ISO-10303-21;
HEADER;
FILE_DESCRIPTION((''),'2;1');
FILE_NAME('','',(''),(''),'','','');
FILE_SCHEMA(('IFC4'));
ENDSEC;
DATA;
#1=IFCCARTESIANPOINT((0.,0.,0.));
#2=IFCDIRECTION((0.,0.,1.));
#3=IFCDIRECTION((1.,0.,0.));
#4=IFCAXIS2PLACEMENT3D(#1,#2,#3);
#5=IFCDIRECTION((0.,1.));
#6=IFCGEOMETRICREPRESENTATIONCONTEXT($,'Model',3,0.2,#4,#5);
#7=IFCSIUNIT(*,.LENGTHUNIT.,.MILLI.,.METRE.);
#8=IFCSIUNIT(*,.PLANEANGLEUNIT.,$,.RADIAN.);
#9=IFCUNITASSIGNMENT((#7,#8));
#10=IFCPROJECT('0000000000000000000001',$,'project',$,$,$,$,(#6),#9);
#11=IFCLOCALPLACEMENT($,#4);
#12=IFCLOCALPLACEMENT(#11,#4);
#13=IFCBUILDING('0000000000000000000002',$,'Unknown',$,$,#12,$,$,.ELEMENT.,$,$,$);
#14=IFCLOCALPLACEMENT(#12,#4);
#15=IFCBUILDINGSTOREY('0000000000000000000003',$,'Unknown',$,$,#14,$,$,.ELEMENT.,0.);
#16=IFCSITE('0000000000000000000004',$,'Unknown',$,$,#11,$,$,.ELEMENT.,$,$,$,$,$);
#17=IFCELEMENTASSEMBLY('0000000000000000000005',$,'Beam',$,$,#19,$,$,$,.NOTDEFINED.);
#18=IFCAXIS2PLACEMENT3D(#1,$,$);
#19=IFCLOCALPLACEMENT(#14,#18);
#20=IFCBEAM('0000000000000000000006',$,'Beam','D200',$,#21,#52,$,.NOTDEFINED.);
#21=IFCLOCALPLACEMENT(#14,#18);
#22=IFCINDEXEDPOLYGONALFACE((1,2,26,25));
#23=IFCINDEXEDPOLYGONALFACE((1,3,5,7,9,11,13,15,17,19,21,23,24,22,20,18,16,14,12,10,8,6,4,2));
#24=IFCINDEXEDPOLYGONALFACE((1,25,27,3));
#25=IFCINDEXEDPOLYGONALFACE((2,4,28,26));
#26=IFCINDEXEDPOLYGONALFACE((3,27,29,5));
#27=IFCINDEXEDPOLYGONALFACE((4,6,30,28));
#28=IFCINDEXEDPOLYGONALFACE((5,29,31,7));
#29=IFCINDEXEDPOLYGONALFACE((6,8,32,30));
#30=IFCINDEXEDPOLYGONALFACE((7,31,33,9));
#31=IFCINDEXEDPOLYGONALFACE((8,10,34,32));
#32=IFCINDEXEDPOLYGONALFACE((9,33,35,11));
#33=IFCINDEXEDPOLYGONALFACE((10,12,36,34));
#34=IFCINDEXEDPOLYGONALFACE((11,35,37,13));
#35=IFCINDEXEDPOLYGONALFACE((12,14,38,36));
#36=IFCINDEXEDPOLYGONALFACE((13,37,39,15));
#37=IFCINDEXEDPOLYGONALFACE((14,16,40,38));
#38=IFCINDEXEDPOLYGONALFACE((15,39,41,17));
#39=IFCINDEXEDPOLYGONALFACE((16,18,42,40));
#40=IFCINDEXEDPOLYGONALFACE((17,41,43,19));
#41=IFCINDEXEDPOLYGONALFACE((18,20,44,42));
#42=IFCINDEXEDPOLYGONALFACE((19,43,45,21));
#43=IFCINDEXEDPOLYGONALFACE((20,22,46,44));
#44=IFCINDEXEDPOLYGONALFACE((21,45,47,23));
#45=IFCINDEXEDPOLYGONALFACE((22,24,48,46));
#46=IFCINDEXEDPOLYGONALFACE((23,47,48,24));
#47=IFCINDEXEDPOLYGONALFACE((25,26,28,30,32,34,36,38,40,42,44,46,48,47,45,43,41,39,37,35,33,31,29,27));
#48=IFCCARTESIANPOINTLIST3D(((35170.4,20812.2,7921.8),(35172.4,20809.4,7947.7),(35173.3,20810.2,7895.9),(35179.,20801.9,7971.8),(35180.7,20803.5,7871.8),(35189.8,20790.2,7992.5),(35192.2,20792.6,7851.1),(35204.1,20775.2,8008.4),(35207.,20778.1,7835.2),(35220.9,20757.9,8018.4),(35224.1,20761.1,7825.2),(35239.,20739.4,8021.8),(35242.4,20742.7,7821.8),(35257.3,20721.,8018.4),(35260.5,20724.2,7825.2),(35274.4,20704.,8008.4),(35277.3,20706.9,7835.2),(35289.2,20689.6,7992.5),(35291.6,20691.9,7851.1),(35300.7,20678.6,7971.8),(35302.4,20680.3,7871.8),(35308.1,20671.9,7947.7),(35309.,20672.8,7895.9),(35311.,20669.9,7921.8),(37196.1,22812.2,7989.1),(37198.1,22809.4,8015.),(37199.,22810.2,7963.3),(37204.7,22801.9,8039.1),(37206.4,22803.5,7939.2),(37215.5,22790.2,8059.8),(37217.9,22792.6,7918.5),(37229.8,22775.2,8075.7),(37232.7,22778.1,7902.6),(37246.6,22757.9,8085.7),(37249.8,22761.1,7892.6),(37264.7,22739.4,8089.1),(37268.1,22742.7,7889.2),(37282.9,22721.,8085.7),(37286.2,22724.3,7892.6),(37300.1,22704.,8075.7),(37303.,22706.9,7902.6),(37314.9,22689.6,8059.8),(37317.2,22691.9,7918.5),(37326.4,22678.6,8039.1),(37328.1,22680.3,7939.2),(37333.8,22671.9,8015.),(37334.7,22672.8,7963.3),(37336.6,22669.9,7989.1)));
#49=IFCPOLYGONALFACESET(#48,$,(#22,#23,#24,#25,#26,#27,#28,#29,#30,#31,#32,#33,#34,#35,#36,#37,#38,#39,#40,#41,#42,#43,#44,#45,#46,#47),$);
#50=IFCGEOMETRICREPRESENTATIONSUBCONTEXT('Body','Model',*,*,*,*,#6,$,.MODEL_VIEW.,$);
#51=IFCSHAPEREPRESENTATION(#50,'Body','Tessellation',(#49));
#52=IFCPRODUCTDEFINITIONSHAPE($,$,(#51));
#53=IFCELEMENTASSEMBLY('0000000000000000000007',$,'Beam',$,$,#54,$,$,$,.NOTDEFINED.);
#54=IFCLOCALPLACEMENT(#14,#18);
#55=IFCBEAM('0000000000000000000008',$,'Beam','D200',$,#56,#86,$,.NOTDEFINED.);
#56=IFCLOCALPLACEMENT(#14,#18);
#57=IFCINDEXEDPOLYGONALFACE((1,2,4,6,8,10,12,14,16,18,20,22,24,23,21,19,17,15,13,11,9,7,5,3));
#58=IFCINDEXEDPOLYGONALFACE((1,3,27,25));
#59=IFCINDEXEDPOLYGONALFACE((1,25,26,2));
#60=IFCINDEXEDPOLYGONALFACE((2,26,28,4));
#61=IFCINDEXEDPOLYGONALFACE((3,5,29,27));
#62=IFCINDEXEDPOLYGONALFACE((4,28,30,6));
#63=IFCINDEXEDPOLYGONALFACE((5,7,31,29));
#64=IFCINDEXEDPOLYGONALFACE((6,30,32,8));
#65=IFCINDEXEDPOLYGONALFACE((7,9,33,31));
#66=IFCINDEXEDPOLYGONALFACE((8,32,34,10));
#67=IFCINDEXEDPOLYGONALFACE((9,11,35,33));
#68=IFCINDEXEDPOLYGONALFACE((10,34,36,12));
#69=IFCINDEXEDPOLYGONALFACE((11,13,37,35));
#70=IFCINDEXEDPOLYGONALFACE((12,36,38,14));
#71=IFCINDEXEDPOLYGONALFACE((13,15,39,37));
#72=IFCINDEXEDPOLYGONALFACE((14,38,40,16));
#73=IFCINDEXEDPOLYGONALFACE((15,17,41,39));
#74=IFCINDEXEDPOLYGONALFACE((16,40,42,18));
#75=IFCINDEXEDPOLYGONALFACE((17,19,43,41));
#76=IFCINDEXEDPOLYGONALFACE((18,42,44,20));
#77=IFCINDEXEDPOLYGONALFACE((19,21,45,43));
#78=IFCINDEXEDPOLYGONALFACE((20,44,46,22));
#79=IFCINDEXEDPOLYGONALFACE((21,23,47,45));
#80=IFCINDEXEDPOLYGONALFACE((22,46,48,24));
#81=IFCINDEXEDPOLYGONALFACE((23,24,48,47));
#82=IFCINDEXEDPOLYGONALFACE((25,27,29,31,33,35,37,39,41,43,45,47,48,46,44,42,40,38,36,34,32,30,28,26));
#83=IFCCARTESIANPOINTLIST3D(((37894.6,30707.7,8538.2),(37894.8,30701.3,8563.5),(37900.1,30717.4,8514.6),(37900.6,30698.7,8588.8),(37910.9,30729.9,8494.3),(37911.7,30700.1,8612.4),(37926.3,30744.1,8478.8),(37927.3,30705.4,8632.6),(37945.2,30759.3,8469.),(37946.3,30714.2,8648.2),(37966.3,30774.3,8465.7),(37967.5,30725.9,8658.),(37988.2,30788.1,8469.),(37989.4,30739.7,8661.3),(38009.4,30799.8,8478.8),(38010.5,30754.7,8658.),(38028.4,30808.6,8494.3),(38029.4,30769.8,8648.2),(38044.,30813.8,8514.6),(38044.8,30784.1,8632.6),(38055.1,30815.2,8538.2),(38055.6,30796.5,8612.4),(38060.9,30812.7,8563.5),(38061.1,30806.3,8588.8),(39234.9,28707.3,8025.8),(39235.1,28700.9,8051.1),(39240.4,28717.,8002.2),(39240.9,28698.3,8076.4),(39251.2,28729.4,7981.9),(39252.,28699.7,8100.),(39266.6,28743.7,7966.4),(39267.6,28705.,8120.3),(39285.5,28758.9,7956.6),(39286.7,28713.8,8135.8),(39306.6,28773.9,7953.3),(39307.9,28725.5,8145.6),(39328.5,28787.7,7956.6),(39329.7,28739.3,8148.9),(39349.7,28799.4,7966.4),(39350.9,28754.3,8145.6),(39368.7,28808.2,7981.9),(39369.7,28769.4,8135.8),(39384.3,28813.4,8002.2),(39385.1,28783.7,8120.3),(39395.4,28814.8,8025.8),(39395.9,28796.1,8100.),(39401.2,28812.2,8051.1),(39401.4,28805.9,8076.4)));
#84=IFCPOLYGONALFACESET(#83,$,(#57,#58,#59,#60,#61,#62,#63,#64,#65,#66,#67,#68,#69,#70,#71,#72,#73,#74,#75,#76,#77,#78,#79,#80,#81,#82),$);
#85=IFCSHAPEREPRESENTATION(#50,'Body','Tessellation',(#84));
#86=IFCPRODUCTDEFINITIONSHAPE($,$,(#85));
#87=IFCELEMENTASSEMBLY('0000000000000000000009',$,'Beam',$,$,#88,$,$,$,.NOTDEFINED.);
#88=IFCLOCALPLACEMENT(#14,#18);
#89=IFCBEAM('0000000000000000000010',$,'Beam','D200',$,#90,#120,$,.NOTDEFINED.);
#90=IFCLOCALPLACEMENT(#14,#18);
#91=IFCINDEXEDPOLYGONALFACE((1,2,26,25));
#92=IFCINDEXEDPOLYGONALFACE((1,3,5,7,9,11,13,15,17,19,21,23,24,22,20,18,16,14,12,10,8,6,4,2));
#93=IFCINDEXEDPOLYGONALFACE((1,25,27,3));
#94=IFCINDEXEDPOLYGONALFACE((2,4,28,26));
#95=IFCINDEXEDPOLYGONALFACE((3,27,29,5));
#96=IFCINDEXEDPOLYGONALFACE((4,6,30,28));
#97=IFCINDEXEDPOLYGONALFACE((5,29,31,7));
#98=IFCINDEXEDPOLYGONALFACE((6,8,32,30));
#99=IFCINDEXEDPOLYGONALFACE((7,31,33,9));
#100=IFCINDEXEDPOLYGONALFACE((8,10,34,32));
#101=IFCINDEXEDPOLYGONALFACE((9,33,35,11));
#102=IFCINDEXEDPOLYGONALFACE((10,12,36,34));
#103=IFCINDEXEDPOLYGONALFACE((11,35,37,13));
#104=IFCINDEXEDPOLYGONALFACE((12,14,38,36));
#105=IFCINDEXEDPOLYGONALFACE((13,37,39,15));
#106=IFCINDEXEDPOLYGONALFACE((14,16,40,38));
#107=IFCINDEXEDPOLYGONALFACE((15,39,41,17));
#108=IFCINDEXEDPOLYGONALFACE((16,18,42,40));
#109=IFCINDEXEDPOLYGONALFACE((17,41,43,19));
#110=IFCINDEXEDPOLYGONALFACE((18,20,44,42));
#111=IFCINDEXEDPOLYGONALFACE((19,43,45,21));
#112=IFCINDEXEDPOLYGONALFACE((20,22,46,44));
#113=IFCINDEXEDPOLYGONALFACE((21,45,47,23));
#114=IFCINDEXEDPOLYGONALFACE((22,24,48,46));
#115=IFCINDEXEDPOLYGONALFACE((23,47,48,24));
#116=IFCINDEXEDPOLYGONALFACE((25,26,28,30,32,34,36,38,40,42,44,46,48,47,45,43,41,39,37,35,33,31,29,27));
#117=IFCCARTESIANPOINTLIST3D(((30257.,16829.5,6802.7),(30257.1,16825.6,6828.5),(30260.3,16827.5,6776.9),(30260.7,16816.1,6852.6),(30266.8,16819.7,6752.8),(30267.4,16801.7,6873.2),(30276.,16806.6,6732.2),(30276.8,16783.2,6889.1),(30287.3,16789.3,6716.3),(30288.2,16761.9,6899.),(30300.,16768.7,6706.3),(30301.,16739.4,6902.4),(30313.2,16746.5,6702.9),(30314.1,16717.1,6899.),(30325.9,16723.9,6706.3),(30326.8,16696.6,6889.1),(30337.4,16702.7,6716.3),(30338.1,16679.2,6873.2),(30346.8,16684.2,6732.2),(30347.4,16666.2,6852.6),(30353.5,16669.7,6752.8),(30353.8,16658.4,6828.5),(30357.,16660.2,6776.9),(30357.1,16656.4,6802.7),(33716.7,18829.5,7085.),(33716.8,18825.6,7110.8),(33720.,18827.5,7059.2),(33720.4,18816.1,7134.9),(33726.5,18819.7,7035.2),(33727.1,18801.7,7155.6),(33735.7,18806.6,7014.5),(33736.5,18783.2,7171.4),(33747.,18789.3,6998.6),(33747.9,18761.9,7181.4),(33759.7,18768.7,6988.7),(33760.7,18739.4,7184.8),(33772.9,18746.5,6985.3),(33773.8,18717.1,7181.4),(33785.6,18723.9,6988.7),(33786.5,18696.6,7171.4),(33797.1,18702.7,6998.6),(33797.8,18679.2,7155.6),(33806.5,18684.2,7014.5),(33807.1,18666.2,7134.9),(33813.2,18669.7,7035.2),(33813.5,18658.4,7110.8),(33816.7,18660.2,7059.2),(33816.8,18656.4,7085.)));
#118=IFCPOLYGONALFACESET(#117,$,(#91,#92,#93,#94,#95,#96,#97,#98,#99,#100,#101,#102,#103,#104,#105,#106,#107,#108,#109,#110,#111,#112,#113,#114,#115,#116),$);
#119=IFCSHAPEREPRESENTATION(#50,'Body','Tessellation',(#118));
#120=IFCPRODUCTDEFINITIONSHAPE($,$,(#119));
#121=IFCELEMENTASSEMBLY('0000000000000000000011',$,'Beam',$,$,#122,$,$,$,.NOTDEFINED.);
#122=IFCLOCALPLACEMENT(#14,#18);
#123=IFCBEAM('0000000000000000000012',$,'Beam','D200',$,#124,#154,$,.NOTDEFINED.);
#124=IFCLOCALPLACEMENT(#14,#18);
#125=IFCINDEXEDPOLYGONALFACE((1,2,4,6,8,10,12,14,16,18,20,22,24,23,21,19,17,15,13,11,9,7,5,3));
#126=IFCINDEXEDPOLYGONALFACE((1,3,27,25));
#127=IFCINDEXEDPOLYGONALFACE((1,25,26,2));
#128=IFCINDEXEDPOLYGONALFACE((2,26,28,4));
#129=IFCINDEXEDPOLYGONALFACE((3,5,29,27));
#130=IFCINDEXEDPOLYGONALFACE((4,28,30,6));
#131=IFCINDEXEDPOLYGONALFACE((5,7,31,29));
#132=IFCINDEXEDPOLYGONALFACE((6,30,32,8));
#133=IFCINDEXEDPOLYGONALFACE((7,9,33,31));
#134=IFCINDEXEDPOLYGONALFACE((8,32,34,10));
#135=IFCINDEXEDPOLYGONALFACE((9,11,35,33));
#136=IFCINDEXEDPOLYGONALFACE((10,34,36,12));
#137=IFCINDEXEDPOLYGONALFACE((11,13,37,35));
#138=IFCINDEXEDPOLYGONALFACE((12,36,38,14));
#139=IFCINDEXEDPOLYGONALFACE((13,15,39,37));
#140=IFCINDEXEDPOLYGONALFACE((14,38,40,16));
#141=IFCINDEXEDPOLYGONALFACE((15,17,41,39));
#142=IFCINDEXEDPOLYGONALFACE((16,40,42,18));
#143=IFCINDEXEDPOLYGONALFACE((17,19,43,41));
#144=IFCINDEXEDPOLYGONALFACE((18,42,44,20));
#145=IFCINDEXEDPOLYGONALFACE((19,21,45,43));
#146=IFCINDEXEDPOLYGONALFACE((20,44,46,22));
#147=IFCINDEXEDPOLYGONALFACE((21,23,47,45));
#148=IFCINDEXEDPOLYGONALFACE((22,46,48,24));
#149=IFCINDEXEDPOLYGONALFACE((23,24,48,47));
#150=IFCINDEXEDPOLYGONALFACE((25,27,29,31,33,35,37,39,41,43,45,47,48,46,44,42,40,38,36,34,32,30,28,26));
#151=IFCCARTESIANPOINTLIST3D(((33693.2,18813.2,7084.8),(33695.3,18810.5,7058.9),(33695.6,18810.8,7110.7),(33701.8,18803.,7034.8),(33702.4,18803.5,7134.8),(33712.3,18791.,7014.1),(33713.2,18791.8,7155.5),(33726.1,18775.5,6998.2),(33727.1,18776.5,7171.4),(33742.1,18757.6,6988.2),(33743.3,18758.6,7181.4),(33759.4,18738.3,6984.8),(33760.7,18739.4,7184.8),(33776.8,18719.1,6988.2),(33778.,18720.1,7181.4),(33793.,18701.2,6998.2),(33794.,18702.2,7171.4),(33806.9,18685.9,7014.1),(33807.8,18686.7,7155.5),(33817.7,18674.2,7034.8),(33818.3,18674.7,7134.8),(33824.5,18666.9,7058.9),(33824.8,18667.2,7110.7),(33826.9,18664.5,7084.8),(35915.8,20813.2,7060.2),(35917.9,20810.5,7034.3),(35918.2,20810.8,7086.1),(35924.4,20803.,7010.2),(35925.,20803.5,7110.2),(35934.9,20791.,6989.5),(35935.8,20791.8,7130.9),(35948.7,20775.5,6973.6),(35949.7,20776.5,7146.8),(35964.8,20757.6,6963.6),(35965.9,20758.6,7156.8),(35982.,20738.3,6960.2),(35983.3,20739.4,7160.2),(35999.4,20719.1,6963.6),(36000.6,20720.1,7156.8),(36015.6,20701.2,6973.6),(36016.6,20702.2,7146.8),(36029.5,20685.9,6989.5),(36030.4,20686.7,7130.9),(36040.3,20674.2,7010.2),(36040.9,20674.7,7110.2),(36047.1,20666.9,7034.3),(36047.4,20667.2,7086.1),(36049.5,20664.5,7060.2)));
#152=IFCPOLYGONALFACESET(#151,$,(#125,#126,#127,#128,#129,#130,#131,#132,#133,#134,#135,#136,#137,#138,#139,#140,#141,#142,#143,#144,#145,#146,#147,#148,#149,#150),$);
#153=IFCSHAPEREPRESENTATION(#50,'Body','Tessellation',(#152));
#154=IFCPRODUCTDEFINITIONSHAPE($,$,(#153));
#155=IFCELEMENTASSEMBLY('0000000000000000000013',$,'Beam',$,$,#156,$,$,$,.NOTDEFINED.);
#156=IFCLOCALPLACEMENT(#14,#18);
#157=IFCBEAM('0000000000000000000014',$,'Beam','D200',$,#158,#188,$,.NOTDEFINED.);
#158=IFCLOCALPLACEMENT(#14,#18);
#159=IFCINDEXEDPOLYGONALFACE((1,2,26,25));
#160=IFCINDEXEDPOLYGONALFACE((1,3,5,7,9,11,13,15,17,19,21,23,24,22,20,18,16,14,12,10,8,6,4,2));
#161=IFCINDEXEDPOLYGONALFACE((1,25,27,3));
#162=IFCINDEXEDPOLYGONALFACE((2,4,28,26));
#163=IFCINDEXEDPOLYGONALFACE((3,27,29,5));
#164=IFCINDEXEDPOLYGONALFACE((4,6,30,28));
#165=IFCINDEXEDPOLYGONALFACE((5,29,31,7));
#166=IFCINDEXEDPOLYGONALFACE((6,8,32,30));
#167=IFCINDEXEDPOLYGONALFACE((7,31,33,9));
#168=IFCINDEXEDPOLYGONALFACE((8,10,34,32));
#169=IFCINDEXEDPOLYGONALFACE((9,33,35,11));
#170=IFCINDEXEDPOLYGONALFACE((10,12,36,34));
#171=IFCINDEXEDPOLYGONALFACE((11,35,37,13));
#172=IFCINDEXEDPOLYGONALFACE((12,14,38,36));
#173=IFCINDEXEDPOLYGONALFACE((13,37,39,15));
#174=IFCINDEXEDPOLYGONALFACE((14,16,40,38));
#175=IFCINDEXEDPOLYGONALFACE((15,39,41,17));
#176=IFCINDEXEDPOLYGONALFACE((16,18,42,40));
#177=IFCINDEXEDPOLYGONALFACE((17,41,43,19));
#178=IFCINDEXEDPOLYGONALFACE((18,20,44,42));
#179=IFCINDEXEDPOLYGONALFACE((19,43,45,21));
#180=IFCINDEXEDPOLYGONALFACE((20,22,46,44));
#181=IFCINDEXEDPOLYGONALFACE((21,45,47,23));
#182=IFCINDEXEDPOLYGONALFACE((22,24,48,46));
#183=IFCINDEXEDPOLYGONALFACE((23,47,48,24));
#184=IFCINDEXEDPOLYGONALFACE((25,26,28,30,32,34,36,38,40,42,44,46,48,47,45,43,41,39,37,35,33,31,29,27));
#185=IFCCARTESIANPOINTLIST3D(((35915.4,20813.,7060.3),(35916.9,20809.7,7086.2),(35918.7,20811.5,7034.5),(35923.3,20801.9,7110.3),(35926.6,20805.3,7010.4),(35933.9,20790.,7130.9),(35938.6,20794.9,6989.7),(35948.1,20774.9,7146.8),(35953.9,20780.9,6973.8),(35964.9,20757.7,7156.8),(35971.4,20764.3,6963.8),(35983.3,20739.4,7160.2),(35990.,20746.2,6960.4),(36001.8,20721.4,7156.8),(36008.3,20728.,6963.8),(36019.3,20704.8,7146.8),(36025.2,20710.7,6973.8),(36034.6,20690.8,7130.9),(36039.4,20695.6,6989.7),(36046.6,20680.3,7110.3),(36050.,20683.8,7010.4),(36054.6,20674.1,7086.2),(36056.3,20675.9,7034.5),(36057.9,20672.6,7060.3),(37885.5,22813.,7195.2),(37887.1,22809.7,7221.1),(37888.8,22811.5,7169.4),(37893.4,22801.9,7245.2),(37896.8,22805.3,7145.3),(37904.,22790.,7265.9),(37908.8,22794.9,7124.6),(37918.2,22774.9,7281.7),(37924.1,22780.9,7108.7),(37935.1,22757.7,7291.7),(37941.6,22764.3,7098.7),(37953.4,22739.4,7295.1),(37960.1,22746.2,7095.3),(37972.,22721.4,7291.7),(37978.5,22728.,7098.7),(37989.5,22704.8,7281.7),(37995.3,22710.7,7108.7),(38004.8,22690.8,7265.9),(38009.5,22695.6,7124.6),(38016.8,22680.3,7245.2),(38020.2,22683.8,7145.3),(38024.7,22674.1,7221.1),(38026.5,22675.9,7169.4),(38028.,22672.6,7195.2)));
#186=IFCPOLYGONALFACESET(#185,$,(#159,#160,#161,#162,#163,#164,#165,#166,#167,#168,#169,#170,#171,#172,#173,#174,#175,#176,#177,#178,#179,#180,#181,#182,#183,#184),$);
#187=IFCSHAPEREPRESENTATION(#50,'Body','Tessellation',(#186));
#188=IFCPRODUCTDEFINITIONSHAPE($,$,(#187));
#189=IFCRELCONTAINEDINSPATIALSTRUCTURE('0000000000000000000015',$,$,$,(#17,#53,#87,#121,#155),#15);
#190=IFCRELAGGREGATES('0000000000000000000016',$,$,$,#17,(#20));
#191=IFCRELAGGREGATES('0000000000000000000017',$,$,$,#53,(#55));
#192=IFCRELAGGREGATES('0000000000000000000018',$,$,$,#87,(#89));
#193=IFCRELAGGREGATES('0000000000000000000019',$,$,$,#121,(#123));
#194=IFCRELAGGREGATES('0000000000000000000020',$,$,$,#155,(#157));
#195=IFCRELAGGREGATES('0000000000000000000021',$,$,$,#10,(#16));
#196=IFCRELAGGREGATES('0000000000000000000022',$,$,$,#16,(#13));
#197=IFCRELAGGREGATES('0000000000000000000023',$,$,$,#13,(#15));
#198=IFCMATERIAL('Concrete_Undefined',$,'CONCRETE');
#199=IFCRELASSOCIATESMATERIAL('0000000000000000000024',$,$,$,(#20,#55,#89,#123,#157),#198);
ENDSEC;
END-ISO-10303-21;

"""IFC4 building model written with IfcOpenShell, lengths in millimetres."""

from ifc_helpers import new_model, si_unit, direction, frame, origin_with_axes, place, context, subcontext, project, spatial, line, indexed_curve, outline, extrude, material, element, aggregate, save


model = new_model("IFC4")

# Units and contexts
model_context = context("Model", 3, precision=0.2, world=origin_with_axes(), true_north=direction((0.0, 1.0)))
body_context = subcontext(model_context, "Body", "Model", "MODEL_VIEW")
ifc_project = project(units=[si_unit("LENGTHUNIT", "METRE", prefix="MILLI"), si_unit("PLANEANGLEUNIT", "RADIAN")], contexts=[model_context])

# Site, building, storey
site_placement = place(None, origin_with_axes())
site = spatial("IfcSite", under=ifc_project, at=site_placement, Name="Unknown", CompositionType="ELEMENT")
building_placement = place(site_placement, origin_with_axes())
building = spatial("IfcBuilding", under=site, at=building_placement, Name="Unknown", CompositionType="ELEMENT")
storey_placement = place(building_placement, origin_with_axes())
storey = spatial("IfcBuildingStorey", under=building, at=storey_placement, Name="Unknown", CompositionType="ELEMENT", Elevation=0.0)

# Element assemblies, beams
ifc_material = material(Name="Concrete_Undefined", Category="CONCRETE")
assembly_1_placement = place(storey_placement, frame((37266.4, 22741.1, 7989.1), z_axis=(-0.702581, 0.711604, 0.0), x_axis=(-0.711405, -0.702385, -0.023654)))
assembly_1 = element("IfcElementAssembly", 1, at=assembly_1_placement, inside=storey, Name="Beam", PredefinedType="NOTDEFINED")
beam_1_placement = place(assembly_1_placement, origin_with_axes())
beam_1 = element("IfcBeam", 2, at=beam_1_placement, material=ifc_material, Name="Beam", Description="D200", PredefinedType="NOTDEFINED", context=body_context, shape_type="SolidModel", body=[
    extrude(outline(indexed_curve([(100.0, 0.0), (96.6, 25.9), (86.6, 50.0), (70.7, 70.7), (50.0, 86.6), (25.9, 96.6), (0.0, 100.0), (-25.9, 96.6), (-50.0, 86.6), (-70.7, 70.7), (-86.6, 50.0), (-96.6, 25.9), (-100.0, 0.0), (-96.6, -25.9), (-86.6, -50.0), (-70.7, -70.7), (-50.0, -86.6), (-25.9, -96.6), (0.0, -100.0), (25.9, -96.6), (50.0, -86.6), (70.7, -70.7), (86.6, -50.0), (96.6, -25.9)], segments=[line(1, 2, 3, 4, 5, 6, 7, 8, 9, 10, 11, 12, 13, 14, 15, 16, 17, 18, 19, 20, 21, 22, 23, 24, 1)])), frame((0.0, 0.0, 0.0), z_axis=(-1.0, 0.0, 0.0), x_axis=(0.0, 0.0, 1.0)), (0.0, 0.0, -1.0), 2847.4),
])
aggregate(assembly_1, [beam_1])
assembly_2_placement = place(storey_placement, frame((37977.8, 30757.0, 8563.5), z_axis=(-0.830763, -0.556626, 0.0), x_axis=(0.544436, -0.81257, -0.20813)))
assembly_2 = element("IfcElementAssembly", 3, at=assembly_2_placement, inside=storey, Name="Beam", PredefinedType="NOTDEFINED")
beam_2_placement = place(assembly_2_placement, origin_with_axes())
beam_2 = element("IfcBeam", 4, at=beam_2_placement, material=ifc_material, Name="Beam", Description="D200", PredefinedType="NOTDEFINED", context=body_context, shape_type="SolidModel", body=[
    extrude(outline(indexed_curve([(100.0, 0.0), (96.6, 25.9), (86.6, 50.0), (70.7, 70.7), (50.0, 86.6), (25.9, 96.6), (0.0, 100.0), (-25.9, 96.6), (-50.0, 86.6), (-70.7, 70.7), (-86.6, 50.0), (-96.6, 25.9), (-100.0, 0.0), (-96.6, -25.9), (-86.6, -50.0), (-70.7, -70.7), (-50.0, -86.6), (-25.9, -96.6), (0.0, -100.0), (25.9, -96.6), (50.0, -86.6), (70.7, -70.7), (86.6, -50.0), (96.6, -25.9)], segments=[line(1, 2, 3, 4, 5, 6, 7, 8, 9, 10, 11, 12, 13, 14, 15, 16, 17, 18, 19, 20, 21, 22, 23, 24, 1)])), frame((0.0, 0.0, 0.0), z_axis=(-1.0, 0.0, 0.0), x_axis=(0.0, 0.0, 1.0)), (0.0, 0.0, -1.0), 2461.8),
])
aggregate(assembly_2, [beam_2])
assembly_3_placement = place(storey_placement, frame((33766.8, 18742.9, 7085.0), z_axis=(-0.500477, 0.86575, 0.0), x_axis=(-0.863597, -0.499232, -0.070477)))
assembly_3 = element("IfcElementAssembly", 5, at=assembly_3_placement, inside=storey, Name="Beam", PredefinedType="NOTDEFINED")
beam_3_placement = place(assembly_3_placement, origin_with_axes())
beam_3 = element("IfcBeam", 6, at=beam_3_placement, material=ifc_material, Name="Beam", Description="D200", PredefinedType="NOTDEFINED", context=body_context, shape_type="SolidModel", body=[
    extrude(outline(indexed_curve([(100.0, 0.0), (96.6, 25.9), (86.6, 50.0), (70.7, 70.7), (50.0, 86.6), (25.9, 96.6), (0.0, 100.0), (-25.9, 96.6), (-50.0, 86.6), (-70.7, 70.7), (-86.6, 50.0), (-96.6, 25.9), (-100.0, 0.0), (-96.6, -25.9), (-86.6, -50.0), (-70.7, -70.7), (-50.0, -86.6), (-25.9, -96.6), (0.0, -100.0), (25.9, -96.6), (50.0, -86.6), (70.7, -70.7), (86.6, -50.0), (96.6, -25.9)], segments=[line(1, 2, 3, 4, 5, 6, 7, 8, 9, 10, 11, 12, 13, 14, 15, 16, 17, 18, 19, 20, 21, 22, 23, 24, 1)])), frame((0.0, 0.0, 0.0), z_axis=(-1.0, 0.0, 0.0), x_axis=(0.0, 0.0, 1.0)), (0.0, 0.0, -1.0), 4006.2),
])
aggregate(assembly_3, [beam_3])
assembly_4_placement = place(storey_placement, frame((35982.7, 20738.9, 7060.2), z_axis=(-0.668901, 0.743351, 0.0), x_axis=(-0.743326, -0.668879, 0.008221)))
assembly_4 = element("IfcElementAssembly", 7, at=assembly_4_placement, inside=storey, Name="Beam", PredefinedType="NOTDEFINED")
beam_4_placement = place(assembly_4_placement, origin_with_axes())
beam_4 = element("IfcBeam", 8, at=beam_4_placement, material=ifc_material, Name="Beam", Description="D200", PredefinedType="NOTDEFINED", context=body_context, shape_type="SolidModel", body=[
    extrude(outline(indexed_curve([(100.0, 0.0), (96.6, 25.9), (86.6, 50.0), (70.7, 70.7), (50.0, 86.6), (25.9, 96.6), (0.0, 100.0), (-25.9, 96.6), (-50.0, 86.6), (-70.7, 70.7), (-86.6, 50.0), (-96.6, 25.9), (-100.0, 0.0), (-96.6, -25.9), (-86.6, -50.0), (-70.7, -70.7), (-50.0, -86.6), (-25.9, -96.6), (0.0, -100.0), (25.9, -96.6), (50.0, -86.6), (70.7, -70.7), (86.6, -50.0), (96.6, -25.9)], segments=[line(1, 2, 3, 4, 5, 6, 7, 8, 9, 10, 11, 12, 13, 14, 15, 16, 17, 18, 19, 20, 21, 22, 23, 24, 1)])), frame((0.0, 0.0, 0.0), z_axis=(-1.0, 0.0, 0.0), x_axis=(0.0, 0.0, 1.0)), (0.0, 0.0, -1.0), 2990.1),
])
aggregate(assembly_4, [beam_4])
assembly_5_placement = place(storey_placement, frame((37956.8, 22742.8, 7195.2), z_axis=(-0.712404, 0.701769, 0.0), x_axis=(-0.700961, -0.711583, -0.048)))
assembly_5 = element("IfcElementAssembly", 9, at=assembly_5_placement, inside=storey, Name="Beam", PredefinedType="NOTDEFINED")
beam_5_placement = place(assembly_5_placement, origin_with_axes())
beam_5 = element("IfcBeam", 10, at=beam_5_placement, material=ifc_material, Name="Beam", Description="D200", PredefinedType="NOTDEFINED", context=body_context, shape_type="SolidModel", body=[
    extrude(outline(indexed_curve([(100.0, 0.0), (96.6, 25.9), (86.6, 50.0), (70.7, 70.7), (50.0, 86.6), (25.9, 96.6), (0.0, 100.0), (-25.9, 96.6), (-50.0, 86.6), (-70.7, 70.7), (-86.6, 50.0), (-96.6, 25.9), (-100.0, 0.0), (-96.6, -25.9), (-86.6, -50.0), (-70.7, -70.7), (-50.0, -86.6), (-25.9, -96.6), (0.0, -100.0), (25.9, -96.6), (50.0, -86.6), (70.7, -70.7), (86.6, -50.0), (96.6, -25.9)], segments=[line(1, 2, 3, 4, 5, 6, 7, 8, 9, 10, 11, 12, 13, 14, 15, 16, 17, 18, 19, 20, 21, 22, 23, 24, 1)])), frame((0.0, 0.0, 0.0), z_axis=(-1.0, 0.0, 0.0), x_axis=(0.0, 0.0, 1.0)), (0.0, 0.0, -1.0), 2810.6),
])
aggregate(assembly_5, [beam_5])

save(model, "model.ifc")
